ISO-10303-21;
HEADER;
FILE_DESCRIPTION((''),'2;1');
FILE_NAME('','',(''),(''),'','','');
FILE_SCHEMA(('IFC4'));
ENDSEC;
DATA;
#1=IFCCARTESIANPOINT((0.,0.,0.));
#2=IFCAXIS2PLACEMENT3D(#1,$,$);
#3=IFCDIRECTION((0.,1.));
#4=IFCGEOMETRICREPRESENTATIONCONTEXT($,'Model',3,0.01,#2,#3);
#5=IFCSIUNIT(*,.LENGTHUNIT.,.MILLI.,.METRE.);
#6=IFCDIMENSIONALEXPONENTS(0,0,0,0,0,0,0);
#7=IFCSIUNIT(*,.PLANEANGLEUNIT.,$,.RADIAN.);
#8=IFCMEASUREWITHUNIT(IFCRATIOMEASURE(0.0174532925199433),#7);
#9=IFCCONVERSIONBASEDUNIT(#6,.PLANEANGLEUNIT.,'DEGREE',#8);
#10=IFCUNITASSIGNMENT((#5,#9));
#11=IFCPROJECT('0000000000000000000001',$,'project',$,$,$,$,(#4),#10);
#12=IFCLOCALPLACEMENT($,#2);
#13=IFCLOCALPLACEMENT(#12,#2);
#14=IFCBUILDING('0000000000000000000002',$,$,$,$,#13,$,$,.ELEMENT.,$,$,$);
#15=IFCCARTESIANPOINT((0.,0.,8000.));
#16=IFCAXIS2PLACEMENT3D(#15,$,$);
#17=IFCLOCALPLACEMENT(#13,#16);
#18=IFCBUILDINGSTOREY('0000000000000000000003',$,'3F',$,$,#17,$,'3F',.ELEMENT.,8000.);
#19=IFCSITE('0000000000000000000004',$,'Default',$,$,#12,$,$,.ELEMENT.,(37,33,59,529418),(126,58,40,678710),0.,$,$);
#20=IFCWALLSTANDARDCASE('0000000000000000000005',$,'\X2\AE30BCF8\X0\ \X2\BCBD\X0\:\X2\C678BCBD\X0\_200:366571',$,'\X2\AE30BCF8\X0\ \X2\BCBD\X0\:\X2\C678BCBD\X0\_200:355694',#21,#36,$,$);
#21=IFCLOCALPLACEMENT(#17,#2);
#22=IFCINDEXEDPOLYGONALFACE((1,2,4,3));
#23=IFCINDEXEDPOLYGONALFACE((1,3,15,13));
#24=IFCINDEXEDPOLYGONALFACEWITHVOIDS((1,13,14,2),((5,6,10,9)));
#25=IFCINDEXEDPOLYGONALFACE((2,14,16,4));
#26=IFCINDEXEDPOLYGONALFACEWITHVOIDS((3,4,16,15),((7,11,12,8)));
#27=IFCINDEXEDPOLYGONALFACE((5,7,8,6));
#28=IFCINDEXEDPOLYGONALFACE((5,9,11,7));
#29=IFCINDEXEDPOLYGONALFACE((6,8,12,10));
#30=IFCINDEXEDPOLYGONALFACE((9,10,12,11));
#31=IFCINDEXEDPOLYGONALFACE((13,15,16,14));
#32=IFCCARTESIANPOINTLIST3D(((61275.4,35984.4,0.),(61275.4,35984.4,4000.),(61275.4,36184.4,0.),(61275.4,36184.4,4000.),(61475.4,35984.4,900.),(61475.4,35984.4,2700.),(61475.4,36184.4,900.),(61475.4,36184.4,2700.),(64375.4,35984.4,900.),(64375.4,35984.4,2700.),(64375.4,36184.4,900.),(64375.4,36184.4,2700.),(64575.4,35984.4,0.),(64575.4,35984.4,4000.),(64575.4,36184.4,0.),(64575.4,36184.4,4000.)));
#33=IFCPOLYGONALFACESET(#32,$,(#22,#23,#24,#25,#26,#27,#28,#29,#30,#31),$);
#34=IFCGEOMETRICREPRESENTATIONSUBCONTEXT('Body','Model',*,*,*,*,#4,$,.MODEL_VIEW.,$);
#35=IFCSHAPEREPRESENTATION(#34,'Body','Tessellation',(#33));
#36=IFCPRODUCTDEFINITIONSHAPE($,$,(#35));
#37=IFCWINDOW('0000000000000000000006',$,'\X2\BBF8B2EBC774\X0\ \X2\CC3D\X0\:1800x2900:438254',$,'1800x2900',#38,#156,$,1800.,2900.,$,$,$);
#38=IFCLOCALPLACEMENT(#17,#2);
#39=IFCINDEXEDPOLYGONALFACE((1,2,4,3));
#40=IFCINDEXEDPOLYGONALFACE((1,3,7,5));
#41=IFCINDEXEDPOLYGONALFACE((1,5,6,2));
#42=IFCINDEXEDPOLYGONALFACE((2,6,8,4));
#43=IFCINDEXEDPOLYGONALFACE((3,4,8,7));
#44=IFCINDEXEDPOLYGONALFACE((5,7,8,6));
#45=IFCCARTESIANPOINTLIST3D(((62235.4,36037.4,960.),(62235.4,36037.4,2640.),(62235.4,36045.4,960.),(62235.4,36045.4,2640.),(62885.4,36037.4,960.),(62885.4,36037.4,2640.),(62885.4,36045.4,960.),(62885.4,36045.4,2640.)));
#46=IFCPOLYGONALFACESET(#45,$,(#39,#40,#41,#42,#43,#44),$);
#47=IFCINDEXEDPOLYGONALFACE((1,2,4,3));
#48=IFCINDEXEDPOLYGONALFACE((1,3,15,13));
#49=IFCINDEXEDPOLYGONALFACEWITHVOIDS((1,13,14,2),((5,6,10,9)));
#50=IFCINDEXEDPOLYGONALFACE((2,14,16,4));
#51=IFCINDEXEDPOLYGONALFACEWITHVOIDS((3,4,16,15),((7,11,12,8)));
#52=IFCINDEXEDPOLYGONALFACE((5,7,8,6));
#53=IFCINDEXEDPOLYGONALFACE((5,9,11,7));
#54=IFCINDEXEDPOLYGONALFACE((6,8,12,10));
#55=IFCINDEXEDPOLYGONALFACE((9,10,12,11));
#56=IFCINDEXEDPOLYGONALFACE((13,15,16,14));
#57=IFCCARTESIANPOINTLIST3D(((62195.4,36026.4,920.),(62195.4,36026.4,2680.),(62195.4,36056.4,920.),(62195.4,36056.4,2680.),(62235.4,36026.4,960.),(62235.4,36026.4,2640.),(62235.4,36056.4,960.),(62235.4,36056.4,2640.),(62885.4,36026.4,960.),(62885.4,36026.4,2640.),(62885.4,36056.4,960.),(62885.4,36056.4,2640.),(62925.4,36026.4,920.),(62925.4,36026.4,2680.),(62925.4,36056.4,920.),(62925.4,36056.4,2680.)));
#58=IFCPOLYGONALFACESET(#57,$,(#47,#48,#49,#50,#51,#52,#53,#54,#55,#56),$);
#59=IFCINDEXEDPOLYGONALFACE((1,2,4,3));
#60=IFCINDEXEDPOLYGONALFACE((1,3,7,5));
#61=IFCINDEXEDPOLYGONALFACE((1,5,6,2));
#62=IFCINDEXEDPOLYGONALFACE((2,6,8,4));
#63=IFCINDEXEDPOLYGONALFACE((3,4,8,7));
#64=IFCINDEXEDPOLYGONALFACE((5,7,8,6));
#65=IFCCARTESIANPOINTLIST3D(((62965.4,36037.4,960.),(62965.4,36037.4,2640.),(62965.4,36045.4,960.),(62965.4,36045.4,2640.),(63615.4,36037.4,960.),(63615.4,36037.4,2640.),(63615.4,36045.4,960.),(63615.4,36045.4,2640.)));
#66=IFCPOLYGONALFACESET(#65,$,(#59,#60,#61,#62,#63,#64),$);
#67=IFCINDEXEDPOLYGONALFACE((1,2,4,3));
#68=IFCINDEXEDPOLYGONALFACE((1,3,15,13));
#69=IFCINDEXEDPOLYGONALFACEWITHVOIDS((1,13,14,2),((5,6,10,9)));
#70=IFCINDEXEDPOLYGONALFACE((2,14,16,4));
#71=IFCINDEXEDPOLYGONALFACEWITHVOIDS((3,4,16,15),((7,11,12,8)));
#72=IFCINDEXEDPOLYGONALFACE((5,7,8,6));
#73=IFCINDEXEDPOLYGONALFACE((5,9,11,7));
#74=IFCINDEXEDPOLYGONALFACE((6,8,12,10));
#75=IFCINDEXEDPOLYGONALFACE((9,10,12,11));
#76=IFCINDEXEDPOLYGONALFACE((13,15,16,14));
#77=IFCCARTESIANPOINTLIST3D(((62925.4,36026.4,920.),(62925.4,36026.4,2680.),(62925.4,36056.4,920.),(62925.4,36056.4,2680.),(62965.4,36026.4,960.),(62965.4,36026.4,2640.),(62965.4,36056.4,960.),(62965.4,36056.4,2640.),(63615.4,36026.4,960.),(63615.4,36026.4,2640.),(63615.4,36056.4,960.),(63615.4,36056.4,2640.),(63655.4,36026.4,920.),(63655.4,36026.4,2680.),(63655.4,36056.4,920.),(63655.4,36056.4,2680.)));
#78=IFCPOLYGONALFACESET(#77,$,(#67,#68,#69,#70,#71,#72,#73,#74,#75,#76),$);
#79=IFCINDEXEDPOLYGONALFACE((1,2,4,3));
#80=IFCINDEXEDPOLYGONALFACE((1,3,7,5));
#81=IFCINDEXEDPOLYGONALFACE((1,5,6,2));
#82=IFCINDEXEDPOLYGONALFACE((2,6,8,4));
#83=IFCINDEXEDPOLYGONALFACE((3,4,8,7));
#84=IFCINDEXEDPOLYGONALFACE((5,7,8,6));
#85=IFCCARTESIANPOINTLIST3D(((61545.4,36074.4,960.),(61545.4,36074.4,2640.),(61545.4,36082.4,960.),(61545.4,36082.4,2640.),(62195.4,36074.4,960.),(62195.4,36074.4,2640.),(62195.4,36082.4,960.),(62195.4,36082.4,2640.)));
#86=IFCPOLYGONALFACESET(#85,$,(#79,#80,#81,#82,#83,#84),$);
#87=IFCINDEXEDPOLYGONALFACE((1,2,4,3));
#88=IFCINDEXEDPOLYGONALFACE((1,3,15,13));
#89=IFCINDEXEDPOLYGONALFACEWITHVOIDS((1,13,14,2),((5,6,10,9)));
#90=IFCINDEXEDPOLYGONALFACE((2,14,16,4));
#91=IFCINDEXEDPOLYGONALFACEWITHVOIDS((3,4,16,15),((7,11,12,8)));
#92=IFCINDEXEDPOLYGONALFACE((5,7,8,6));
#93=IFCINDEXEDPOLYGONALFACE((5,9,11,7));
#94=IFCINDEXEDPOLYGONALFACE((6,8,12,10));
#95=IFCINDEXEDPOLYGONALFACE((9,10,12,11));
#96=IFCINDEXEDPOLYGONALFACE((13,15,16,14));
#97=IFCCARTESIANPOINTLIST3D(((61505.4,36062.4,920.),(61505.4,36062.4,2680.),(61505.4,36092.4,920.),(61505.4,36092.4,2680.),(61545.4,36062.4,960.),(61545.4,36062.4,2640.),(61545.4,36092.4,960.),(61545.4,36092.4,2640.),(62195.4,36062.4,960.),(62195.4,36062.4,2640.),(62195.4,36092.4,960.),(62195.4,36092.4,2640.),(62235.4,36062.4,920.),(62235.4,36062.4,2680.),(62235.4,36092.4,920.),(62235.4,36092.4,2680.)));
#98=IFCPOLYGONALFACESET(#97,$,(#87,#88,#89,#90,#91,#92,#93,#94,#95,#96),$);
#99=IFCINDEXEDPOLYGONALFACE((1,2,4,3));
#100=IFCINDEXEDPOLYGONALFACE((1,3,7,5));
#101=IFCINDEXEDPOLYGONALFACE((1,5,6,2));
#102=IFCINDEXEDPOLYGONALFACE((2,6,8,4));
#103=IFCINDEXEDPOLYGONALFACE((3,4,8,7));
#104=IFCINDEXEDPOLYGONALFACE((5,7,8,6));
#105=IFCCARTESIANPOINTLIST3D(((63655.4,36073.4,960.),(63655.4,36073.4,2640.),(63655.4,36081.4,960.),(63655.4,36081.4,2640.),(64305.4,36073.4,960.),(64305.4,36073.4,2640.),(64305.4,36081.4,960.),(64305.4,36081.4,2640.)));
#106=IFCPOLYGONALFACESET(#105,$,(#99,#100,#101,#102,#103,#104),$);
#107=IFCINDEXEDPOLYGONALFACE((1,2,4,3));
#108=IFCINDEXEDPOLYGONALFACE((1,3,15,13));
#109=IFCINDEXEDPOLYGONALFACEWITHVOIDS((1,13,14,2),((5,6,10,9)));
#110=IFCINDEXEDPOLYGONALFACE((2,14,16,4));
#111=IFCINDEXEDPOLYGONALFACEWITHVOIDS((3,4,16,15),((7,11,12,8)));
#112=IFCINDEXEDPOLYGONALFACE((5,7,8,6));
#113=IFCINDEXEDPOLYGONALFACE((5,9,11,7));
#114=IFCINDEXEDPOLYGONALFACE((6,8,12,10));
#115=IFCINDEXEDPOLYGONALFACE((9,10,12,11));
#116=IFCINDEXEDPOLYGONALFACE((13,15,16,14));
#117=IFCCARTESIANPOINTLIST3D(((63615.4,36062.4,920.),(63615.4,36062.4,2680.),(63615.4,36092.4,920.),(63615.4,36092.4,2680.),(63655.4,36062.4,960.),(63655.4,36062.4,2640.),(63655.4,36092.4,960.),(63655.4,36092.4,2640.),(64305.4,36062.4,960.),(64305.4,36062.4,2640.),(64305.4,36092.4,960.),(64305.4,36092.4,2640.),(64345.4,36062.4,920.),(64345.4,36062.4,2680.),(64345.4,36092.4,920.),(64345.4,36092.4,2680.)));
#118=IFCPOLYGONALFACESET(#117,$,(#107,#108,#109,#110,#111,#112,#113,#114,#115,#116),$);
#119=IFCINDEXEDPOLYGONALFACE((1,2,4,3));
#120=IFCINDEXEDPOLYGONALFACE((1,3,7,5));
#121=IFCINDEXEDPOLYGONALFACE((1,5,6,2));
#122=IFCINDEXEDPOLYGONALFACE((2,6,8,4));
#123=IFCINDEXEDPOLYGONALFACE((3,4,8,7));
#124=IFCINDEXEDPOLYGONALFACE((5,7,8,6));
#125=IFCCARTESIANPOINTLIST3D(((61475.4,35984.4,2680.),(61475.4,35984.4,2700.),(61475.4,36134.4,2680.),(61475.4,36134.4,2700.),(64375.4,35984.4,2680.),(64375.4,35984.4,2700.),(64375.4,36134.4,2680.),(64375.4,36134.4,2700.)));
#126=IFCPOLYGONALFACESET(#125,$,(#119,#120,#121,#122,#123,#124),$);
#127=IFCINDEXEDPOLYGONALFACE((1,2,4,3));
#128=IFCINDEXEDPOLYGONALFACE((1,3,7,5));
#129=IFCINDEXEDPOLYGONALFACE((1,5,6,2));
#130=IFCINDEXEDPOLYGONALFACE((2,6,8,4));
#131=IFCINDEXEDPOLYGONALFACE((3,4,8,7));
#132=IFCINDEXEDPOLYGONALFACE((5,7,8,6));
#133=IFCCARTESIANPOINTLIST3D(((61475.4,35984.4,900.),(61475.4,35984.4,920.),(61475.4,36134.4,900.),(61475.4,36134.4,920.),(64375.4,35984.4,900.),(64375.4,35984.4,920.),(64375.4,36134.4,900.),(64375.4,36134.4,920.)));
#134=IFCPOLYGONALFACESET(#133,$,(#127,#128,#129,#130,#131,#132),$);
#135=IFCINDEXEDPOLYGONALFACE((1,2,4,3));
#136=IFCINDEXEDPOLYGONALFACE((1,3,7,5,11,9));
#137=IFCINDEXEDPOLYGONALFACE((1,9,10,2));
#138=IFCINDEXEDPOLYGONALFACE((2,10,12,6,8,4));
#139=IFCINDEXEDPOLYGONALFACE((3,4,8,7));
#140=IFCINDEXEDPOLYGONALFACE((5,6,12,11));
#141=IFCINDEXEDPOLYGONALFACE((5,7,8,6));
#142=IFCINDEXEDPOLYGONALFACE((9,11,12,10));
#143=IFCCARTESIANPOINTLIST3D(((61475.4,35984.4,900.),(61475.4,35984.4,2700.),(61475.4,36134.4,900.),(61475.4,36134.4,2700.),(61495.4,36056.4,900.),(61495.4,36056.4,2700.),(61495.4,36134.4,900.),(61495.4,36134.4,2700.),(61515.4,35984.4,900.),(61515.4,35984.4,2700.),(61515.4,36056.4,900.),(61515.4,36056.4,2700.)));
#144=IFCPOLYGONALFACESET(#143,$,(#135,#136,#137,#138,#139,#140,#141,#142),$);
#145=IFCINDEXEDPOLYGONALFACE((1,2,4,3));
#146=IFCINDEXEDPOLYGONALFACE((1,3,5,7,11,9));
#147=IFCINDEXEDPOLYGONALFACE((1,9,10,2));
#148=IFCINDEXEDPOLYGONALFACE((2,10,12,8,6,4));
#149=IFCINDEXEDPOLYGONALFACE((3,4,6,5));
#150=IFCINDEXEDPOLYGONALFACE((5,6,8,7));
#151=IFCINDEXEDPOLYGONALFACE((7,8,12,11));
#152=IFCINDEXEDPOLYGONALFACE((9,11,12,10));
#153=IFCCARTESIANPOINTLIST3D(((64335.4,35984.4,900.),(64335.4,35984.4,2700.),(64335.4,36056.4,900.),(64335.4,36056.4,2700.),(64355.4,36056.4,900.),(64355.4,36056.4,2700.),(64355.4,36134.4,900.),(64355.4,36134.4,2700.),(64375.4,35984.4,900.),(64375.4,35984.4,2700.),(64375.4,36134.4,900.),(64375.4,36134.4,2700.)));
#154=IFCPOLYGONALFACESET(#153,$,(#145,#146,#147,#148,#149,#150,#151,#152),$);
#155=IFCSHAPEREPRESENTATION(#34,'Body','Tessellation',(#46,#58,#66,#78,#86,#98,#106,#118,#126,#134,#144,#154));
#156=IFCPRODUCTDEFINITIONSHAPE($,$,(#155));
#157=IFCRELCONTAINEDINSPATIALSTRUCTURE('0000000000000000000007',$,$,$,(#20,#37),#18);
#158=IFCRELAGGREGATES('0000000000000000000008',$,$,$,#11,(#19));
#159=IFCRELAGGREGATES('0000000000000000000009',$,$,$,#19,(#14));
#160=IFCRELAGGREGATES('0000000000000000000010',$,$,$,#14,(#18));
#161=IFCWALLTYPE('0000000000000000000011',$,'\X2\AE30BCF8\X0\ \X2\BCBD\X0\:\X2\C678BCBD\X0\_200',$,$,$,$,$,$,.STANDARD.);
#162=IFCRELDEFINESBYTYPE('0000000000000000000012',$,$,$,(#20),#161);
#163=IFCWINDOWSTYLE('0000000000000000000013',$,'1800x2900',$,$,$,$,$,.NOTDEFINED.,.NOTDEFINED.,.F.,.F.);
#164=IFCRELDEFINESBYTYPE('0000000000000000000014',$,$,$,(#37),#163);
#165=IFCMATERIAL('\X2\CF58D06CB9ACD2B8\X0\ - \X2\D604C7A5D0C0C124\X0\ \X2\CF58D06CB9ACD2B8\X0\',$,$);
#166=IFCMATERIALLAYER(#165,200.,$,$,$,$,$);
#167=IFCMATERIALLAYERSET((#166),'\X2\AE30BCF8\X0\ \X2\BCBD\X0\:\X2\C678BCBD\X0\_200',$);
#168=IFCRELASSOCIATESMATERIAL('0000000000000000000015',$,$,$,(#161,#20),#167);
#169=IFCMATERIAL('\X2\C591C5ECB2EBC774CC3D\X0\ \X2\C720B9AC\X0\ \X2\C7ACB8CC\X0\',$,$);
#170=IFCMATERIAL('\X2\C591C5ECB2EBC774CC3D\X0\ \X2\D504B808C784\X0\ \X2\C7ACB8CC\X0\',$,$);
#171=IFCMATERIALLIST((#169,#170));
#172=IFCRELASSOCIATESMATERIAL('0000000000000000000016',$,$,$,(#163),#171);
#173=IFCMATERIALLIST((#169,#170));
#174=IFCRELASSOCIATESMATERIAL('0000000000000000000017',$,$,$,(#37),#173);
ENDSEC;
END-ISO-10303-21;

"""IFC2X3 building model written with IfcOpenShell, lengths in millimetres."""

from ifc_helpers import new_model, entity, si_unit, converted_unit, direction, frame, frame_2d, origin, origin_2d_with_axis, place, context, subcontext, project, spatial, polyline, rectangle, outline, extrude, source, transform, mapped, material, material_list, layer, layer_set, layer_usage, type_object, type_shapes, element, fill, save


model = new_model("IFC2X3")

# Units and contexts
model_context = context("Model", 3, precision=0.01, world=origin(), true_north=direction((0.0, 1.0)))
body_context = subcontext(model_context, "Body", "Model", "MODEL_VIEW")
ifc_project = project(units=[si_unit("LENGTHUNIT", "METRE", prefix="MILLI"), converted_unit("PLANEANGLEUNIT", "DEGREE", entity("IfcRatioMeasure", 0.0174532925199433), si_unit("PLANEANGLEUNIT", "RADIAN"), dimensions=[0, 0, 0, 0, 0, 0, 0])], contexts=[model_context])

# Site, building, storey
site_placement = place(None, origin())
site = spatial("IfcSite", under=ifc_project, at=site_placement, Name="Default", CompositionType="ELEMENT", RefLatitude=(37, 33, 59, 529418), RefLongitude=(126, 58, 40, 678710), RefElevation=0.0)
building_placement = place(site_placement, origin())
building = spatial("IfcBuilding", under=site, at=building_placement, CompositionType="ELEMENT")
storey_placement = place(building_placement, frame((0.0, 0.0, 8000.0)))
storey = spatial("IfcBuildingStorey", under=building, at=storey_placement, Name="3F", LongName="3F", CompositionType="ELEMENT", Elevation=8000.0)

# Wall, opening, window
ifc_material_1 = material(Name="콘크리트 - 현장타설 콘크리트")
ifc_layer_1 = layer(ifc_material_1, 200.0)
ifc_layer_set_1 = layer_set([ifc_layer_1], Name="기본 벽:외벽_200")
wall_type_1 = type_object("IfcWallType", Name="기본 벽:외벽_200", PredefinedType="STANDARD", material=ifc_layer_set_1)
ifc_material_2 = material(Name="양여닫이창 유리 재료")
ifc_material_3 = material(Name="양여닫이창 프레임 재료")
ifc_material_list_1 = material_list([ifc_material_2, ifc_material_3])
window_style = type_object("IfcWindowStyle", Name="1800x2900", ConstructionType="NOTDEFINED", OperationType="NOTDEFINED", ParameterTakesPrecedence=False, Sizeable=False, material=ifc_material_list_1)
shared_shape_1 = source(origin(), body_context, "Body", "SweptSolid", [
    extrude(rectangle(XDim=8.0, YDim=650.0, at=frame_2d((0.0, 0.0), x_axis=(1.0, 0.0))), frame((1815.0, 143.0, 60.0), z_axis=(0.0, 0.0, 1.0), x_axis=(0.0, 1.0, 0.0)), (0.0, 0.0, 1.0), 1680.0),
    extrude(outline(polyline([(-880.0, -365.0), (880.0, -365.0), (880.0, 365.0), (-880.0, 365.0), (-880.0, -365.0)]), holes=[polyline([(840.0, -325.0), (-840.0, -325.0), (-840.0, 325.0), (840.0, 325.0), (840.0, -325.0)])]), frame((1815.0, 128.0, 900.0), z_axis=(0.0, 1.0, 0.0), x_axis=(0.0, 0.0, -1.0)), (0.0, 0.0, 1.0), 30.0),
    extrude(rectangle(XDim=8.0, YDim=650.0, at=frame_2d((0.0, 0.0), x_axis=(1.0, 0.0))), frame((1085.0, 143.0, 60.0), z_axis=(0.0, 0.0, 1.0), x_axis=(0.0, 1.0, 0.0)), (0.0, 0.0, 1.0), 1680.0),
    extrude(outline(polyline([(-880.0, -365.0), (880.0, -365.0), (880.0, 365.0), (-880.0, 365.0), (-880.0, -365.0)]), holes=[polyline([(840.0, -325.0), (-840.0, -325.0), (-840.0, 325.0), (840.0, 325.0), (840.0, -325.0)])]), frame((1085.0, 128.0, 900.0), z_axis=(0.0, 1.0, 0.0), x_axis=(0.0, 0.0, -1.0)), (0.0, 0.0, 1.0), 30.0),
    extrude(rectangle(XDim=8.0, YDim=650.0, at=frame_2d((0.0, 0.0), x_axis=(1.0, 0.0))), frame((2505.0, 106.0, 60.0), z_axis=(0.0, 0.0, 1.0), x_axis=(0.0, 1.0, 0.0)), (0.0, 0.0, 1.0), 1680.0),
    extrude(outline(polyline([(-880.0, -365.0), (880.0, -365.0), (880.0, 365.0), (-880.0, 365.0), (-880.0, -365.0)]), holes=[polyline([(840.0, -325.0), (-840.0, -325.0), (-840.0, 325.0), (840.0, 325.0), (840.0, -325.0)])]), frame((2505.0, 92.0, 900.0), z_axis=(0.0, 1.0, 0.0), x_axis=(0.0, 0.0, -1.0)), (0.0, 0.0, 1.0), 30.0),
    extrude(rectangle(XDim=8.0, YDim=650.0, at=origin_2d_with_axis()), frame((395.0, 107.0, 60.0), z_axis=(0.0, 0.0, 1.0), x_axis=(0.0, 1.0, 0.0)), (0.0, 0.0, 1.0), 1680.0),
    extrude(outline(polyline([(-880.0, -365.0), (880.0, -365.0), (880.0, 365.0), (-880.0, 365.0), (-880.0, -365.0)]), holes=[polyline([(840.0, -325.0), (-840.0, -325.0), (-840.0, 325.0), (840.0, 325.0), (840.0, -325.0)])]), frame((395.0, 92.0, 900.0), z_axis=(0.0, 1.0, 0.0), x_axis=(0.0, 0.0, -1.0)), (0.0, 0.0, 1.0), 30.0),
    extrude(rectangle(XDim=2900.0, YDim=150.0, at=origin_2d_with_axis()), frame((1450.0, 125.0, 1780.0), z_axis=(0.0, 0.0, 1.0), x_axis=(-1.0, 0.0, 0.0)), (0.0, 0.0, 1.0), 20.0),
    extrude(rectangle(XDim=2900.0, YDim=150.0, at=origin_2d_with_axis()), frame((1450.0, 125.0, 0.0), z_axis=(0.0, 0.0, 1.0), x_axis=(-1.0, 0.0, 0.0)), (0.0, 0.0, 1.0), 20.0),
    extrude(outline(polyline([(-74.0, -20.0), (-2.0, -20.0), (-2.0, 0.0), (76.0, 0.0), (76.0, 20.0), (-74.0, 20.0), (-74.0, -20.0)])), frame((2880.0, 126.0, 0.0), z_axis=(0.0, 0.0, 1.0), x_axis=(0.0, -1.0, 0.0)), (0.0, 0.0, 1.0), 1800.0),
    extrude(outline(polyline([(-20.0, -74.0), (20.0, -74.0), (20.0, 76.0), (0.0, 76.0), (0.0, -2.0), (-20.0, -2.0), (-20.0, -74.0)])), frame((20.0, 126.0, 0.0), z_axis=(0.0, 0.0, 1.0), x_axis=(-1.0, 0.0, 0.0)), (0.0, 0.0, 1.0), 1800.0),
])
type_shapes(window_style, [shared_shape_1])
ifc_layer_usage_1 = layer_usage(ifc_layer_set_1, "AXIS2", "NEGATIVE", 100.0)
wall_1_placement = place(storey_placement, frame((64575.4, 36084.4, 0.0), z_axis=(0.0, 0.0, 1.0), x_axis=(-1.0, 0.0, 0.0)))
wall_1 = element("IfcWallStandardCase", 1, at=wall_1_placement, inside=storey, type_object=wall_type_1, material=ifc_layer_usage_1, Name="기본 벽:외벽_200:366571", ObjectType="기본 벽:외벽_200:355694", context=body_context, shape_type="SweptSolid", body=[
    extrude(rectangle(XDim=3300.0, YDim=200.0, at=frame_2d((1650.0, 0.0), x_axis=(-1.0, 0.0))), origin(), (0.0, 0.0, 1.0), 4000.0),
])
opening_1_placement = place(wall_1_placement, frame((200.0, -100.0, 900.0)))
opening_1 = element("IfcOpeningElement", 2, at=opening_1_placement, cuts=wall_1, ObjectType="Opening", context=body_context, shape_type="SweptSolid", body=[
    extrude(rectangle(XDim=1800.0, YDim=2900.0, at=frame_2d((900.0, 1450.0), x_axis=(1.0, 0.0))), frame((0.0, 0.0, 0.0), z_axis=(0.0, 1.0, 0.0), x_axis=(0.0, 0.0, 1.0)), (0.0, 0.0, 1.0), 200.0),
])
ifc_material_list_2 = material_list([ifc_material_2, ifc_material_3])
window_1_placement = place(opening_1_placement, origin())
window_1 = element("IfcWindow", 3, at=window_1_placement, inside=storey, type_object=window_style, material=ifc_material_list_2, Name="미닫이 창:1800x2900:438254", ObjectType="1800x2900", OverallHeight=1800.0, OverallWidth=2900.0, context=body_context, shape_type="MappedRepresentation", body=[
    mapped(shared_shape_1, transform((0.0, 0.0, 0.0), scale=1.0)),
])
fill(opening_1, window_1)

save(model, "model.ifc")
